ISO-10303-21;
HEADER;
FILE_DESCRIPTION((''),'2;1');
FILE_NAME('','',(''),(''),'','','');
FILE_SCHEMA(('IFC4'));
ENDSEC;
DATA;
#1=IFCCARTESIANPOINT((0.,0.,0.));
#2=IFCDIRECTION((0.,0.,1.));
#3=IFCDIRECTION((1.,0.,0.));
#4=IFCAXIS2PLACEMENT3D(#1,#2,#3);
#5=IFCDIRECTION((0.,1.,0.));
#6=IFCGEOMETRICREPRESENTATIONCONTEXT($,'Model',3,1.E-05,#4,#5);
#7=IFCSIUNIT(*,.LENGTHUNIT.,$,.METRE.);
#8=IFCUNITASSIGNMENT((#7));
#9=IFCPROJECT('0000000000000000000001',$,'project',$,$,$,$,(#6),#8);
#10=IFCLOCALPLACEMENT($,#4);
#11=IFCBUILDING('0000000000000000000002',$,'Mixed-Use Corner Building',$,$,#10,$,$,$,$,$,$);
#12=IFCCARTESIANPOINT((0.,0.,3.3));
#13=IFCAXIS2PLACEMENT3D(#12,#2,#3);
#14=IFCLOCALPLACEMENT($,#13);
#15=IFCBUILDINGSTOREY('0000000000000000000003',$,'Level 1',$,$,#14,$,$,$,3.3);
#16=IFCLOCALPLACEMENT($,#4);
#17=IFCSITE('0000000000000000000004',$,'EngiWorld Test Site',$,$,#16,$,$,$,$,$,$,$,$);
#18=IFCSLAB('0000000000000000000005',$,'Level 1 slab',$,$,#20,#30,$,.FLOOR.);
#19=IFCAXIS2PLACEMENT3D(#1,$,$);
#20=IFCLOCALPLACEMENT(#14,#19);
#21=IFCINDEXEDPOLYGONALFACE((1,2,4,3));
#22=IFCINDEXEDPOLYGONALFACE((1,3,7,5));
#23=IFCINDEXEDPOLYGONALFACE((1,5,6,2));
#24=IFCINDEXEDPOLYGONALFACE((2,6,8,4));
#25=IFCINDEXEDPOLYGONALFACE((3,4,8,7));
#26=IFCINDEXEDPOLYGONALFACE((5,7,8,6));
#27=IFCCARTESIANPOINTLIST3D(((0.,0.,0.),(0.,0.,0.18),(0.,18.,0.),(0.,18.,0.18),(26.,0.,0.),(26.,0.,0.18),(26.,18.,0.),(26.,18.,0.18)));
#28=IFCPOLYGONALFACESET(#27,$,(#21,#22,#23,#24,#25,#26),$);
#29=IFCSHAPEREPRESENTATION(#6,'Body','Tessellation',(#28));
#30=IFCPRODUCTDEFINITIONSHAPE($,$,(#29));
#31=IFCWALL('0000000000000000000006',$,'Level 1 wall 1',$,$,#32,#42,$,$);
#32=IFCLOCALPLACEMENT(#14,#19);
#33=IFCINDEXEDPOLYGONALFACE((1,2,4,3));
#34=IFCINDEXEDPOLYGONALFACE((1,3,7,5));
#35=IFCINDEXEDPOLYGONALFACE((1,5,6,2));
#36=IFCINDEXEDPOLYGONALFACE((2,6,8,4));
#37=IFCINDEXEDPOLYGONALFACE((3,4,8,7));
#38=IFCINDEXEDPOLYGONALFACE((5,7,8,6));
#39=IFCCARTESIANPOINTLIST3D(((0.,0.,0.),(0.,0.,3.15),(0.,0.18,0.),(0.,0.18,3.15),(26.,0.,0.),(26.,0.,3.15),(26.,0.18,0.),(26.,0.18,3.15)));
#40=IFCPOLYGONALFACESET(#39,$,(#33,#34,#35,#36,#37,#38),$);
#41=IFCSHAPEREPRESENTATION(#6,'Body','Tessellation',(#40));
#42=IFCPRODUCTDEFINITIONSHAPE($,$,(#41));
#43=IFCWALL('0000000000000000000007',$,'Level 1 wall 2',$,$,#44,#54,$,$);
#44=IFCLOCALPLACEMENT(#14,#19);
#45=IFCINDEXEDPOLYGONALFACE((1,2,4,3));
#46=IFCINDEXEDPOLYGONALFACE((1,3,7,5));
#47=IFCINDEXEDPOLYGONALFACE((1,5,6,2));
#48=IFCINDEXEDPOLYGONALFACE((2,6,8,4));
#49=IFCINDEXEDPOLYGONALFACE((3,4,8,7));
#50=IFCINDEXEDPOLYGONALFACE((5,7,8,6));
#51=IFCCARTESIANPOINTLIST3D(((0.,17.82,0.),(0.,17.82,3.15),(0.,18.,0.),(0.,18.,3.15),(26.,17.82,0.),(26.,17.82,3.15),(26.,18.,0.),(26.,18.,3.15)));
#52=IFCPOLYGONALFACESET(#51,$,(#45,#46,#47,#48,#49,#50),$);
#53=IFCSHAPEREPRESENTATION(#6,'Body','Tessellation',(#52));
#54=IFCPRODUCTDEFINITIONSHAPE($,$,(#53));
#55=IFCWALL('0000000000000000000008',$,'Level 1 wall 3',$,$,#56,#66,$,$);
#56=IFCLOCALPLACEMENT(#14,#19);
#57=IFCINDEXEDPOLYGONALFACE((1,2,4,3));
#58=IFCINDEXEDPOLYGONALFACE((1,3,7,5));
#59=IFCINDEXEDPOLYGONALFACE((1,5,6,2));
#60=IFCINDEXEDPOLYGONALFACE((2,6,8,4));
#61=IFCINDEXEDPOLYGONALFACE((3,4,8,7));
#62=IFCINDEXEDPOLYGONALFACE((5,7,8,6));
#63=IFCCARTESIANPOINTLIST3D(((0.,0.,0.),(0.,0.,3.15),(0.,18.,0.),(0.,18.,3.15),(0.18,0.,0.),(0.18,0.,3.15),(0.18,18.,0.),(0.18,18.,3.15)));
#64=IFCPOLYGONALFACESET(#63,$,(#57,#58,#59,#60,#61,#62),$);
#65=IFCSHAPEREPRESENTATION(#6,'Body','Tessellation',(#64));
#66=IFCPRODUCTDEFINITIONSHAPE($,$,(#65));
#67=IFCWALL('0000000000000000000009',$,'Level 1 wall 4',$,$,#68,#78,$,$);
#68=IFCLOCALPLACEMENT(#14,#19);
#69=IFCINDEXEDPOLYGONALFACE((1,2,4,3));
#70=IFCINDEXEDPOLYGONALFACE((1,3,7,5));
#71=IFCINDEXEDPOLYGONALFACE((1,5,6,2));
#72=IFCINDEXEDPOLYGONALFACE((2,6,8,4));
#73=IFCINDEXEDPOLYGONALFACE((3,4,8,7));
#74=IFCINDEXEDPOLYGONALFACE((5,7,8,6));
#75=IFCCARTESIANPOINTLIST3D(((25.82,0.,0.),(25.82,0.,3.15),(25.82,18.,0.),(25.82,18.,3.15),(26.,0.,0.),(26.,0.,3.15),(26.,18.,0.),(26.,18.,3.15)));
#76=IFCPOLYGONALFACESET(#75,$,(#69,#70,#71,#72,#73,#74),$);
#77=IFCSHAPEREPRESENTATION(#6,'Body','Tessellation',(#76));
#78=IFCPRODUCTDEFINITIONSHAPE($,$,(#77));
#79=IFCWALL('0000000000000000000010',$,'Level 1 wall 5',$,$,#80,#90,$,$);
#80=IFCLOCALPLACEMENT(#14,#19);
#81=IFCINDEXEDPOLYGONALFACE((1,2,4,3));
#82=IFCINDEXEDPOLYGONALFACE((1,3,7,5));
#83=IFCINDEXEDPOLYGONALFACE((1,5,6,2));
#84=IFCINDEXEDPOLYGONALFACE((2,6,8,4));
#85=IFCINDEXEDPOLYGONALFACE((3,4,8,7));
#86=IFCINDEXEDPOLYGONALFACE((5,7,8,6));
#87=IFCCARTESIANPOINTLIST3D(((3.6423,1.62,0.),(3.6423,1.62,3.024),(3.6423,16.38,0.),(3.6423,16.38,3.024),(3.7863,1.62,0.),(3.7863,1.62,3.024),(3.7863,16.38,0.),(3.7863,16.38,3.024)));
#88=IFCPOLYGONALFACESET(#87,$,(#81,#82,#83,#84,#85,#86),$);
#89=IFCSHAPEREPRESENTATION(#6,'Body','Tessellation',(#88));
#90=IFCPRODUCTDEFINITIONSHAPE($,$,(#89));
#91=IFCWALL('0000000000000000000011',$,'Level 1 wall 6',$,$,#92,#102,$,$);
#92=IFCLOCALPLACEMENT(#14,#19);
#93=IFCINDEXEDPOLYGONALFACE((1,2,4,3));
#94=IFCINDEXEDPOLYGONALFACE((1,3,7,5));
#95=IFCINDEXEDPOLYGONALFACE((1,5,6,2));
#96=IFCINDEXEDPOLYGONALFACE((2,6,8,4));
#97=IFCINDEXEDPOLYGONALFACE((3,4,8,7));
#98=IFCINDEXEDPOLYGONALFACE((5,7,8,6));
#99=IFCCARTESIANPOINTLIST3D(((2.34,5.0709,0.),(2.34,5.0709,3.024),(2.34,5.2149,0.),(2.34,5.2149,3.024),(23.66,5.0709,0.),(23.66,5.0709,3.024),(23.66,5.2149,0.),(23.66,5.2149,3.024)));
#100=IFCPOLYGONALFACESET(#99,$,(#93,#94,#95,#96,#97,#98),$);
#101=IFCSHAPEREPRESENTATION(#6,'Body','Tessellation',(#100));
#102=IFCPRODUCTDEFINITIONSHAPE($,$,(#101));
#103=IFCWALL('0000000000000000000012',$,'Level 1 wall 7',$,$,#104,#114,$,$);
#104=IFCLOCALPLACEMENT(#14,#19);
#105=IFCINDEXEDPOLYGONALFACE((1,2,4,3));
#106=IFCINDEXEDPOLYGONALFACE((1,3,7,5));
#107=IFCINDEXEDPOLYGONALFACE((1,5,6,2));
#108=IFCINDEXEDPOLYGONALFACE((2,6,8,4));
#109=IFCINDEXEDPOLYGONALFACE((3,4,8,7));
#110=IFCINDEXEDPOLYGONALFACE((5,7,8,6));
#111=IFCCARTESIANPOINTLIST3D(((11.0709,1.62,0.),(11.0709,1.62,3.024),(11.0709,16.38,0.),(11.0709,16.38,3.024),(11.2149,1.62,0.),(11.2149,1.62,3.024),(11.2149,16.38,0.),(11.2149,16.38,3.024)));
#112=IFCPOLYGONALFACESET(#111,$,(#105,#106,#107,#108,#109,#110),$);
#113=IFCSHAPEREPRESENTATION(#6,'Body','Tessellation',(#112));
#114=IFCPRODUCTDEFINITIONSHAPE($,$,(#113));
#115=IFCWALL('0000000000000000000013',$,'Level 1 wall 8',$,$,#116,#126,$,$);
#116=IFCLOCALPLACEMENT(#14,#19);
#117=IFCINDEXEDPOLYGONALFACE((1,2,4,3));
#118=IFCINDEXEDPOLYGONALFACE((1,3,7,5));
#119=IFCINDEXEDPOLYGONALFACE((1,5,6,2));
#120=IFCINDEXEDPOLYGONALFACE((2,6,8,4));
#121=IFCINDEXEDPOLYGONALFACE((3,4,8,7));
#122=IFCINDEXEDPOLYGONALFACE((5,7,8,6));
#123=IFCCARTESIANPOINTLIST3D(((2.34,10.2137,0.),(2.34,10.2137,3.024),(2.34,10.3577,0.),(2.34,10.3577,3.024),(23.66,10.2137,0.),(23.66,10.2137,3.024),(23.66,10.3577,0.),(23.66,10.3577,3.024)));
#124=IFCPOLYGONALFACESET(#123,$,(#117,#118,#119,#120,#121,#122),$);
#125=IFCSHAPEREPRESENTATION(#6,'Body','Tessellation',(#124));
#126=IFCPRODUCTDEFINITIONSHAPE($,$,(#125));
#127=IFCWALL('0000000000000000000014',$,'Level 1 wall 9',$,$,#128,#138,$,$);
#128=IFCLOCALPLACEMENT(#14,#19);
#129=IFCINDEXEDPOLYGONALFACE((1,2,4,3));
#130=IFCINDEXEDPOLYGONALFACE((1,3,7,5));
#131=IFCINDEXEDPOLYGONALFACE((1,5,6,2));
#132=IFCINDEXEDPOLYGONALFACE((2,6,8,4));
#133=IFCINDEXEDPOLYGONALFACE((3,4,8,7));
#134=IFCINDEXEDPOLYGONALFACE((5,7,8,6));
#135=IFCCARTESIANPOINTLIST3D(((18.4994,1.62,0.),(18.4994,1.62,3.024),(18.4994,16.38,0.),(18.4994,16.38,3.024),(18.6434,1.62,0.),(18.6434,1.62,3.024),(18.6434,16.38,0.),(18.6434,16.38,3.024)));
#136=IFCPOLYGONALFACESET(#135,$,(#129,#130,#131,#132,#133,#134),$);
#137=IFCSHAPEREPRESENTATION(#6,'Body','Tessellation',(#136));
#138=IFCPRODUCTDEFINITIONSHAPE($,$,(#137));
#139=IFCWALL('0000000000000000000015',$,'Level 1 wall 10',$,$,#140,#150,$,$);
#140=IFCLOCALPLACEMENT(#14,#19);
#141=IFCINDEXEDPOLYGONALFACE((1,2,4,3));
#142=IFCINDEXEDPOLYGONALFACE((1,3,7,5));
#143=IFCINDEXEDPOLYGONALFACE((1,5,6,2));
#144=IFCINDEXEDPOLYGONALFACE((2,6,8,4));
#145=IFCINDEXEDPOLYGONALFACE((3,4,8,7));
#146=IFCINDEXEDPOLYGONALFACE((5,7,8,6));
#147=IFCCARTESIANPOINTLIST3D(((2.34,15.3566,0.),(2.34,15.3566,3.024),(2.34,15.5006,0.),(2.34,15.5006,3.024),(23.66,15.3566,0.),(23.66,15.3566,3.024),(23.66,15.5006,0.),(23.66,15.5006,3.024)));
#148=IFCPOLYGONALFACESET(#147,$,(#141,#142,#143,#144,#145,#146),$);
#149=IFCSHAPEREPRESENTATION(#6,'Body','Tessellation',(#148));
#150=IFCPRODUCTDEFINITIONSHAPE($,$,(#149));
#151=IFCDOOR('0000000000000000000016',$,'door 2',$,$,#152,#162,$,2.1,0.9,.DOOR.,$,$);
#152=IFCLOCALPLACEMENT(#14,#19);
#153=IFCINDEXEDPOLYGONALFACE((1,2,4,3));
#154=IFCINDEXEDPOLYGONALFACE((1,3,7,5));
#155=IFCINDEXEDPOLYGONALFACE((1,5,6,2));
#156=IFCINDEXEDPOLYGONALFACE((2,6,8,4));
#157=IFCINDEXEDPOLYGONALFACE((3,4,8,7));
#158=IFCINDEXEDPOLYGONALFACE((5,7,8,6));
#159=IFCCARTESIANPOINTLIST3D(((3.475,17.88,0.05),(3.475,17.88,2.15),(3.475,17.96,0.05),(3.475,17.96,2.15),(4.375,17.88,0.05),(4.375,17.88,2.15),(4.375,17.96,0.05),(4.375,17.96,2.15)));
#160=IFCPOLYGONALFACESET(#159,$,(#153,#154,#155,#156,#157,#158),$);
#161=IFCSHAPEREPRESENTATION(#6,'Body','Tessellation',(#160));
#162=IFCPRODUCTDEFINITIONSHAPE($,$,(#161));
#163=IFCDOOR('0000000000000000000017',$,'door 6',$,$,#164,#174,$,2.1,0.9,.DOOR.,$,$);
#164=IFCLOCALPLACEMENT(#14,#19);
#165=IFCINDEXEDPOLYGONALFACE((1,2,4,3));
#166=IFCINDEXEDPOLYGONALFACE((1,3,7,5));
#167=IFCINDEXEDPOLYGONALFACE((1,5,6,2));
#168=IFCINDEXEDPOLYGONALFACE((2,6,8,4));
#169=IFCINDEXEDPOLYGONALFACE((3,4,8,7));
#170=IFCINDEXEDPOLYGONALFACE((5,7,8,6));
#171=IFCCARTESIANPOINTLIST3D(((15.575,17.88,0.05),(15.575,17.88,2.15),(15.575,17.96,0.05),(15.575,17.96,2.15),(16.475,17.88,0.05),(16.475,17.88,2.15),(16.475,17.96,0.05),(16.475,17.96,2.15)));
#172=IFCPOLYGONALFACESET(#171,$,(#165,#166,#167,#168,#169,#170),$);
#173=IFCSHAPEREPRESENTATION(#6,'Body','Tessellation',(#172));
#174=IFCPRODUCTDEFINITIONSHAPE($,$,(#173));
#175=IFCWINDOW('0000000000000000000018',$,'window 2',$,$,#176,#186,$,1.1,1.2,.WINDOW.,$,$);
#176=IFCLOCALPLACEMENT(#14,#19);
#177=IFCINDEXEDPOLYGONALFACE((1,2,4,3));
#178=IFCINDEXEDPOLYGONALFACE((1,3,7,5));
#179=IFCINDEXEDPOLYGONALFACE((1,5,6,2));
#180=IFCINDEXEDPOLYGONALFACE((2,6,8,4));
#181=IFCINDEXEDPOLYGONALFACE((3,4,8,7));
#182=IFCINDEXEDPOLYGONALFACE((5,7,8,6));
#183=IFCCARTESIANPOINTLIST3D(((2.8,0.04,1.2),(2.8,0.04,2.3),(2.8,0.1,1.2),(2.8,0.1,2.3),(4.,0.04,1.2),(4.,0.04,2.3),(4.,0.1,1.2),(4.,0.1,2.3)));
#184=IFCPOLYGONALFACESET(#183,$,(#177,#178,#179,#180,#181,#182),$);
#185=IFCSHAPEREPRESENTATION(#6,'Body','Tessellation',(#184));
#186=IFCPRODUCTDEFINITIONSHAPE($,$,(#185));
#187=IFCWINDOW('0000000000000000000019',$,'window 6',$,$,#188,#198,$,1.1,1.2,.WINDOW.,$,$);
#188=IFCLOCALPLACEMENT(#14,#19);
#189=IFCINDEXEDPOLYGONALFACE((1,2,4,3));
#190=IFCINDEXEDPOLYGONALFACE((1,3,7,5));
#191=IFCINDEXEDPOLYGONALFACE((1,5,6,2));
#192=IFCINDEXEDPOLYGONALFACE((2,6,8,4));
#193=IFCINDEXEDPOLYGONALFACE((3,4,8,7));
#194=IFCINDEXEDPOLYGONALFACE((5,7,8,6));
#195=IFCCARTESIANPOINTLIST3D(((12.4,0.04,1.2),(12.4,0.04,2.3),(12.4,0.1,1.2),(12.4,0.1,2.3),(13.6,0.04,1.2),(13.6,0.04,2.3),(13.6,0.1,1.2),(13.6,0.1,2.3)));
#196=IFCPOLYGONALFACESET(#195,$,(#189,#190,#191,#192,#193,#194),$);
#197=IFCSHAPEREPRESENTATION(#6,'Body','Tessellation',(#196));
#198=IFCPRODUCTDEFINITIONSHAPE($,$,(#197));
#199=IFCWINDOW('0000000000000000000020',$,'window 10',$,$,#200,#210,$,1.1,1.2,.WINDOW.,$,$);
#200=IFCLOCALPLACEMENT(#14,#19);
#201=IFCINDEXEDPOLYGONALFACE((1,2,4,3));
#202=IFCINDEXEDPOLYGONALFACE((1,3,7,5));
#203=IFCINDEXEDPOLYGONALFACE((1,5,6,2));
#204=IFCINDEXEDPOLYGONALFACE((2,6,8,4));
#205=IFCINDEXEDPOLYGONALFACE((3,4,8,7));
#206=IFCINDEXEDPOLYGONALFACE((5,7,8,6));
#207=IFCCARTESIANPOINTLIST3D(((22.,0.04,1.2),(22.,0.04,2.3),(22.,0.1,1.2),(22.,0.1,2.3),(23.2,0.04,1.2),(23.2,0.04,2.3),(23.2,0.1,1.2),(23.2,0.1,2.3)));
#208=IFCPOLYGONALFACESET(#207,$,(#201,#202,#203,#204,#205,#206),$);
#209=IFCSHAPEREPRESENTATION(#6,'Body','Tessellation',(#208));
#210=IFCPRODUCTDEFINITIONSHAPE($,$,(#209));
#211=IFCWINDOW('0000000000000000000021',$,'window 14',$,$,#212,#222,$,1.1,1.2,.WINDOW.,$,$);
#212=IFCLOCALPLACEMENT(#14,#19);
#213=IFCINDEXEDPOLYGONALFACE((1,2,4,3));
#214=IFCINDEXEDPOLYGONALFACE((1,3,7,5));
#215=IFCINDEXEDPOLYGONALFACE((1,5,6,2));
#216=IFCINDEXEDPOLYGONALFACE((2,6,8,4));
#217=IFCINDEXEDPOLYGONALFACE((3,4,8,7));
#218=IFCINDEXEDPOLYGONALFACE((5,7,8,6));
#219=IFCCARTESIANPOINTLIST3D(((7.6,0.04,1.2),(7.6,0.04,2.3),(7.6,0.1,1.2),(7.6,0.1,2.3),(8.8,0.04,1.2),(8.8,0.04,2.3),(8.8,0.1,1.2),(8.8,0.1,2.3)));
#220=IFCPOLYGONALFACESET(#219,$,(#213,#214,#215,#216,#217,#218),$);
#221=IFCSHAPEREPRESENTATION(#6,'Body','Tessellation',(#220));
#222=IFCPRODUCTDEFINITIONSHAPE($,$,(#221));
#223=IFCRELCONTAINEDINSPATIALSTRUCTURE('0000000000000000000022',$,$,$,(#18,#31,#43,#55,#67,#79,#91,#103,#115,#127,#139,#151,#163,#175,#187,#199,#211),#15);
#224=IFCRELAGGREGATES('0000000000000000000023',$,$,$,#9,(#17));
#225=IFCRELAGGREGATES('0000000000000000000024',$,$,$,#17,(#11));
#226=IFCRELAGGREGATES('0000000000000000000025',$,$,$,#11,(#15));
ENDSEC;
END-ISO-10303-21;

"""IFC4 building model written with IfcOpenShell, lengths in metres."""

from ifc_helpers import new_model, si_unit, direction, frame, origin_with_axes, origin_2d_with_axis, place, context, project, spatial, rectangle, extrude, element, save


model = new_model("IFC4")

# Units and contexts
model_context = context("Model", 3, precision=1e-05, world=origin_with_axes(), true_north=direction((0.0, 1.0, 0.0)))
ifc_project = project(units=[si_unit("LENGTHUNIT", "METRE")], contexts=[model_context])

# Site, building, storey
site_placement = place(None, origin_with_axes())
site = spatial("IfcSite", under=ifc_project, at=site_placement, Name="EngiWorld Test Site")
building_placement = place(None, origin_with_axes())
building = spatial("IfcBuilding", under=site, at=building_placement, Name="Mixed-Use Corner Building")
storey_placement = place(None, frame((0.0, 0.0, 3.3), z_axis=(0.0, 0.0, 1.0), x_axis=(1.0, 0.0, 0.0)))
storey = spatial("IfcBuildingStorey", under=building, at=storey_placement, Name="Level 1", Elevation=3.3)

# Slab
slab_placement = place(None, frame((13.0, 9.0, 3.3), z_axis=(0.0, 0.0, 1.0), x_axis=(1.0, 0.0, 0.0)))
element("IfcSlab", 1, at=slab_placement, inside=storey, Name="Level 1 slab", PredefinedType="FLOOR", context=model_context, shape_type="SweptSolid", body=[
    extrude(rectangle(XDim=26.0, YDim=18.0, at=origin_2d_with_axis()), origin_with_axes(), (0.0, 0.0, 1.0), 0.18),
])

# Walls
for number, where, z_axis, x_axis, name in (
    (2, (13.0, 0.09, 3.3), (0.0, 0.0, 1.0), (1.0, 0.0, 0.0), "Level 1 wall 1"),
    (3, (13.0, 17.91, 3.3), (0.0, 0.0, 1.0), (1.0, 0.0, 0.0), "Level 1 wall 2"),
):
    element("IfcWall", number, at=place(None, frame(where, z_axis=z_axis, x_axis=x_axis)), inside=storey, Name=name, context=model_context, shape_type="SweptSolid", body=[
        extrude(rectangle(XDim=26.0, YDim=0.18, at=origin_2d_with_axis()), origin_with_axes(), (0.0, 0.0, 1.0), 3.15),
    ])
for number, where, z_axis, x_axis, name in (
    (4, (0.09, 9.0, 3.3), (0.0, 0.0, 1.0), (1.0, 0.0, 0.0), "Level 1 wall 3"),
    (5, (25.91, 9.0, 3.3), (0.0, 0.0, 1.0), (1.0, 0.0, 0.0), "Level 1 wall 4"),
):
    element("IfcWall", number, at=place(None, frame(where, z_axis=z_axis, x_axis=x_axis)), inside=storey, Name=name, context=model_context, shape_type="SweptSolid", body=[
        extrude(rectangle(XDim=0.18, YDim=18.0, at=origin_2d_with_axis()), origin_with_axes(), (0.0, 0.0, 1.0), 3.15),
    ])
wall_1_placement = place(None, frame((3.7143, 9.0, 3.3), z_axis=(0.0, 0.0, 1.0), x_axis=(1.0, 0.0, 0.0)))
element("IfcWall", 6, at=wall_1_placement, inside=storey, Name="Level 1 wall 5", context=model_context, shape_type="SweptSolid", body=[
    extrude(rectangle(XDim=0.144, YDim=14.76, at=origin_2d_with_axis()), origin_with_axes(), (0.0, 0.0, 1.0), 3.024),
])
wall_2_placement = place(None, frame((13.0, 5.1429, 3.3), z_axis=(0.0, 0.0, 1.0), x_axis=(1.0, 0.0, 0.0)))
element("IfcWall", 7, at=wall_2_placement, inside=storey, Name="Level 1 wall 6", context=model_context, shape_type="SweptSolid", body=[
    extrude(rectangle(XDim=21.32, YDim=0.144, at=origin_2d_with_axis()), origin_with_axes(), (0.0, 0.0, 1.0), 3.024),
])
wall_3_placement = place(None, frame((11.1429, 9.0, 3.3), z_axis=(0.0, 0.0, 1.0), x_axis=(1.0, 0.0, 0.0)))
element("IfcWall", 8, at=wall_3_placement, inside=storey, Name="Level 1 wall 7", context=model_context, shape_type="SweptSolid", body=[
    extrude(rectangle(XDim=0.144, YDim=14.76, at=origin_2d_with_axis()), origin_with_axes(), (0.0, 0.0, 1.0), 3.024),
])
wall_4_placement = place(None, frame((13.0, 10.2857, 3.3), z_axis=(0.0, 0.0, 1.0), x_axis=(1.0, 0.0, 0.0)))
element("IfcWall", 9, at=wall_4_placement, inside=storey, Name="Level 1 wall 8", context=model_context, shape_type="SweptSolid", body=[
    extrude(rectangle(XDim=21.32, YDim=0.144, at=origin_2d_with_axis()), origin_with_axes(), (0.0, 0.0, 1.0), 3.024),
])
wall_5_placement = place(None, frame((18.5714, 9.0, 3.3), z_axis=(0.0, 0.0, 1.0), x_axis=(1.0, 0.0, 0.0)))
element("IfcWall", 10, at=wall_5_placement, inside=storey, Name="Level 1 wall 9", context=model_context, shape_type="SweptSolid", body=[
    extrude(rectangle(XDim=0.144, YDim=14.76, at=origin_2d_with_axis()), origin_with_axes(), (0.0, 0.0, 1.0), 3.024),
])
wall_6_placement = place(None, frame((13.0, 15.4286, 3.3), z_axis=(0.0, 0.0, 1.0), x_axis=(1.0, 0.0, 0.0)))
element("IfcWall", 11, at=wall_6_placement, inside=storey, Name="Level 1 wall 10", context=model_context, shape_type="SweptSolid", body=[
    extrude(rectangle(XDim=21.32, YDim=0.144, at=origin_2d_with_axis()), origin_with_axes(), (0.0, 0.0, 1.0), 3.024),
])

# Doors
for number, where, z_axis, x_axis, name in (
    (12, (3.925, 17.92, 3.35), (0.0, 0.0, 1.0), (1.0, 0.0, 0.0), "door 2"),
    (13, (16.025, 17.92, 3.35), (0.0, 0.0, 1.0), (1.0, 0.0, 0.0), "door 6"),
):
    element("IfcDoor", number, at=place(None, frame(where, z_axis=z_axis, x_axis=x_axis)), inside=storey, Name=name, OverallHeight=2.1, OverallWidth=0.9, PredefinedType="DOOR", context=model_context, shape_type="SweptSolid", body=[
        extrude(rectangle(XDim=0.9, YDim=0.08, at=origin_2d_with_axis()), origin_with_axes(), (0.0, 0.0, 1.0), 2.1),
    ])

# Windows
for number, where, z_axis, x_axis, name in (
    (14, (3.4, 0.07, 4.5), (0.0, 0.0, 1.0), (1.0, 0.0, 0.0), "window 2"),
    (15, (13.0, 0.07, 4.5), (0.0, 0.0, 1.0), (1.0, 0.0, 0.0), "window 6"),
    (16, (22.6, 0.07, 4.5), (0.0, 0.0, 1.0), (1.0, 0.0, 0.0), "window 10"),
    (17, (8.2, 0.07, 4.5), (0.0, 0.0, 1.0), (1.0, 0.0, 0.0), "window 14"),
):
    element("IfcWindow", number, at=place(None, frame(where, z_axis=z_axis, x_axis=x_axis)), inside=storey, Name=name, OverallHeight=1.1, OverallWidth=1.2, PredefinedType="WINDOW", context=model_context, shape_type="SweptSolid", body=[
        extrude(rectangle(XDim=1.2, YDim=0.06, at=origin_2d_with_axis()), origin_with_axes(), (0.0, 0.0, 1.0), 1.1),
    ])

save(model, "model.ifc")
